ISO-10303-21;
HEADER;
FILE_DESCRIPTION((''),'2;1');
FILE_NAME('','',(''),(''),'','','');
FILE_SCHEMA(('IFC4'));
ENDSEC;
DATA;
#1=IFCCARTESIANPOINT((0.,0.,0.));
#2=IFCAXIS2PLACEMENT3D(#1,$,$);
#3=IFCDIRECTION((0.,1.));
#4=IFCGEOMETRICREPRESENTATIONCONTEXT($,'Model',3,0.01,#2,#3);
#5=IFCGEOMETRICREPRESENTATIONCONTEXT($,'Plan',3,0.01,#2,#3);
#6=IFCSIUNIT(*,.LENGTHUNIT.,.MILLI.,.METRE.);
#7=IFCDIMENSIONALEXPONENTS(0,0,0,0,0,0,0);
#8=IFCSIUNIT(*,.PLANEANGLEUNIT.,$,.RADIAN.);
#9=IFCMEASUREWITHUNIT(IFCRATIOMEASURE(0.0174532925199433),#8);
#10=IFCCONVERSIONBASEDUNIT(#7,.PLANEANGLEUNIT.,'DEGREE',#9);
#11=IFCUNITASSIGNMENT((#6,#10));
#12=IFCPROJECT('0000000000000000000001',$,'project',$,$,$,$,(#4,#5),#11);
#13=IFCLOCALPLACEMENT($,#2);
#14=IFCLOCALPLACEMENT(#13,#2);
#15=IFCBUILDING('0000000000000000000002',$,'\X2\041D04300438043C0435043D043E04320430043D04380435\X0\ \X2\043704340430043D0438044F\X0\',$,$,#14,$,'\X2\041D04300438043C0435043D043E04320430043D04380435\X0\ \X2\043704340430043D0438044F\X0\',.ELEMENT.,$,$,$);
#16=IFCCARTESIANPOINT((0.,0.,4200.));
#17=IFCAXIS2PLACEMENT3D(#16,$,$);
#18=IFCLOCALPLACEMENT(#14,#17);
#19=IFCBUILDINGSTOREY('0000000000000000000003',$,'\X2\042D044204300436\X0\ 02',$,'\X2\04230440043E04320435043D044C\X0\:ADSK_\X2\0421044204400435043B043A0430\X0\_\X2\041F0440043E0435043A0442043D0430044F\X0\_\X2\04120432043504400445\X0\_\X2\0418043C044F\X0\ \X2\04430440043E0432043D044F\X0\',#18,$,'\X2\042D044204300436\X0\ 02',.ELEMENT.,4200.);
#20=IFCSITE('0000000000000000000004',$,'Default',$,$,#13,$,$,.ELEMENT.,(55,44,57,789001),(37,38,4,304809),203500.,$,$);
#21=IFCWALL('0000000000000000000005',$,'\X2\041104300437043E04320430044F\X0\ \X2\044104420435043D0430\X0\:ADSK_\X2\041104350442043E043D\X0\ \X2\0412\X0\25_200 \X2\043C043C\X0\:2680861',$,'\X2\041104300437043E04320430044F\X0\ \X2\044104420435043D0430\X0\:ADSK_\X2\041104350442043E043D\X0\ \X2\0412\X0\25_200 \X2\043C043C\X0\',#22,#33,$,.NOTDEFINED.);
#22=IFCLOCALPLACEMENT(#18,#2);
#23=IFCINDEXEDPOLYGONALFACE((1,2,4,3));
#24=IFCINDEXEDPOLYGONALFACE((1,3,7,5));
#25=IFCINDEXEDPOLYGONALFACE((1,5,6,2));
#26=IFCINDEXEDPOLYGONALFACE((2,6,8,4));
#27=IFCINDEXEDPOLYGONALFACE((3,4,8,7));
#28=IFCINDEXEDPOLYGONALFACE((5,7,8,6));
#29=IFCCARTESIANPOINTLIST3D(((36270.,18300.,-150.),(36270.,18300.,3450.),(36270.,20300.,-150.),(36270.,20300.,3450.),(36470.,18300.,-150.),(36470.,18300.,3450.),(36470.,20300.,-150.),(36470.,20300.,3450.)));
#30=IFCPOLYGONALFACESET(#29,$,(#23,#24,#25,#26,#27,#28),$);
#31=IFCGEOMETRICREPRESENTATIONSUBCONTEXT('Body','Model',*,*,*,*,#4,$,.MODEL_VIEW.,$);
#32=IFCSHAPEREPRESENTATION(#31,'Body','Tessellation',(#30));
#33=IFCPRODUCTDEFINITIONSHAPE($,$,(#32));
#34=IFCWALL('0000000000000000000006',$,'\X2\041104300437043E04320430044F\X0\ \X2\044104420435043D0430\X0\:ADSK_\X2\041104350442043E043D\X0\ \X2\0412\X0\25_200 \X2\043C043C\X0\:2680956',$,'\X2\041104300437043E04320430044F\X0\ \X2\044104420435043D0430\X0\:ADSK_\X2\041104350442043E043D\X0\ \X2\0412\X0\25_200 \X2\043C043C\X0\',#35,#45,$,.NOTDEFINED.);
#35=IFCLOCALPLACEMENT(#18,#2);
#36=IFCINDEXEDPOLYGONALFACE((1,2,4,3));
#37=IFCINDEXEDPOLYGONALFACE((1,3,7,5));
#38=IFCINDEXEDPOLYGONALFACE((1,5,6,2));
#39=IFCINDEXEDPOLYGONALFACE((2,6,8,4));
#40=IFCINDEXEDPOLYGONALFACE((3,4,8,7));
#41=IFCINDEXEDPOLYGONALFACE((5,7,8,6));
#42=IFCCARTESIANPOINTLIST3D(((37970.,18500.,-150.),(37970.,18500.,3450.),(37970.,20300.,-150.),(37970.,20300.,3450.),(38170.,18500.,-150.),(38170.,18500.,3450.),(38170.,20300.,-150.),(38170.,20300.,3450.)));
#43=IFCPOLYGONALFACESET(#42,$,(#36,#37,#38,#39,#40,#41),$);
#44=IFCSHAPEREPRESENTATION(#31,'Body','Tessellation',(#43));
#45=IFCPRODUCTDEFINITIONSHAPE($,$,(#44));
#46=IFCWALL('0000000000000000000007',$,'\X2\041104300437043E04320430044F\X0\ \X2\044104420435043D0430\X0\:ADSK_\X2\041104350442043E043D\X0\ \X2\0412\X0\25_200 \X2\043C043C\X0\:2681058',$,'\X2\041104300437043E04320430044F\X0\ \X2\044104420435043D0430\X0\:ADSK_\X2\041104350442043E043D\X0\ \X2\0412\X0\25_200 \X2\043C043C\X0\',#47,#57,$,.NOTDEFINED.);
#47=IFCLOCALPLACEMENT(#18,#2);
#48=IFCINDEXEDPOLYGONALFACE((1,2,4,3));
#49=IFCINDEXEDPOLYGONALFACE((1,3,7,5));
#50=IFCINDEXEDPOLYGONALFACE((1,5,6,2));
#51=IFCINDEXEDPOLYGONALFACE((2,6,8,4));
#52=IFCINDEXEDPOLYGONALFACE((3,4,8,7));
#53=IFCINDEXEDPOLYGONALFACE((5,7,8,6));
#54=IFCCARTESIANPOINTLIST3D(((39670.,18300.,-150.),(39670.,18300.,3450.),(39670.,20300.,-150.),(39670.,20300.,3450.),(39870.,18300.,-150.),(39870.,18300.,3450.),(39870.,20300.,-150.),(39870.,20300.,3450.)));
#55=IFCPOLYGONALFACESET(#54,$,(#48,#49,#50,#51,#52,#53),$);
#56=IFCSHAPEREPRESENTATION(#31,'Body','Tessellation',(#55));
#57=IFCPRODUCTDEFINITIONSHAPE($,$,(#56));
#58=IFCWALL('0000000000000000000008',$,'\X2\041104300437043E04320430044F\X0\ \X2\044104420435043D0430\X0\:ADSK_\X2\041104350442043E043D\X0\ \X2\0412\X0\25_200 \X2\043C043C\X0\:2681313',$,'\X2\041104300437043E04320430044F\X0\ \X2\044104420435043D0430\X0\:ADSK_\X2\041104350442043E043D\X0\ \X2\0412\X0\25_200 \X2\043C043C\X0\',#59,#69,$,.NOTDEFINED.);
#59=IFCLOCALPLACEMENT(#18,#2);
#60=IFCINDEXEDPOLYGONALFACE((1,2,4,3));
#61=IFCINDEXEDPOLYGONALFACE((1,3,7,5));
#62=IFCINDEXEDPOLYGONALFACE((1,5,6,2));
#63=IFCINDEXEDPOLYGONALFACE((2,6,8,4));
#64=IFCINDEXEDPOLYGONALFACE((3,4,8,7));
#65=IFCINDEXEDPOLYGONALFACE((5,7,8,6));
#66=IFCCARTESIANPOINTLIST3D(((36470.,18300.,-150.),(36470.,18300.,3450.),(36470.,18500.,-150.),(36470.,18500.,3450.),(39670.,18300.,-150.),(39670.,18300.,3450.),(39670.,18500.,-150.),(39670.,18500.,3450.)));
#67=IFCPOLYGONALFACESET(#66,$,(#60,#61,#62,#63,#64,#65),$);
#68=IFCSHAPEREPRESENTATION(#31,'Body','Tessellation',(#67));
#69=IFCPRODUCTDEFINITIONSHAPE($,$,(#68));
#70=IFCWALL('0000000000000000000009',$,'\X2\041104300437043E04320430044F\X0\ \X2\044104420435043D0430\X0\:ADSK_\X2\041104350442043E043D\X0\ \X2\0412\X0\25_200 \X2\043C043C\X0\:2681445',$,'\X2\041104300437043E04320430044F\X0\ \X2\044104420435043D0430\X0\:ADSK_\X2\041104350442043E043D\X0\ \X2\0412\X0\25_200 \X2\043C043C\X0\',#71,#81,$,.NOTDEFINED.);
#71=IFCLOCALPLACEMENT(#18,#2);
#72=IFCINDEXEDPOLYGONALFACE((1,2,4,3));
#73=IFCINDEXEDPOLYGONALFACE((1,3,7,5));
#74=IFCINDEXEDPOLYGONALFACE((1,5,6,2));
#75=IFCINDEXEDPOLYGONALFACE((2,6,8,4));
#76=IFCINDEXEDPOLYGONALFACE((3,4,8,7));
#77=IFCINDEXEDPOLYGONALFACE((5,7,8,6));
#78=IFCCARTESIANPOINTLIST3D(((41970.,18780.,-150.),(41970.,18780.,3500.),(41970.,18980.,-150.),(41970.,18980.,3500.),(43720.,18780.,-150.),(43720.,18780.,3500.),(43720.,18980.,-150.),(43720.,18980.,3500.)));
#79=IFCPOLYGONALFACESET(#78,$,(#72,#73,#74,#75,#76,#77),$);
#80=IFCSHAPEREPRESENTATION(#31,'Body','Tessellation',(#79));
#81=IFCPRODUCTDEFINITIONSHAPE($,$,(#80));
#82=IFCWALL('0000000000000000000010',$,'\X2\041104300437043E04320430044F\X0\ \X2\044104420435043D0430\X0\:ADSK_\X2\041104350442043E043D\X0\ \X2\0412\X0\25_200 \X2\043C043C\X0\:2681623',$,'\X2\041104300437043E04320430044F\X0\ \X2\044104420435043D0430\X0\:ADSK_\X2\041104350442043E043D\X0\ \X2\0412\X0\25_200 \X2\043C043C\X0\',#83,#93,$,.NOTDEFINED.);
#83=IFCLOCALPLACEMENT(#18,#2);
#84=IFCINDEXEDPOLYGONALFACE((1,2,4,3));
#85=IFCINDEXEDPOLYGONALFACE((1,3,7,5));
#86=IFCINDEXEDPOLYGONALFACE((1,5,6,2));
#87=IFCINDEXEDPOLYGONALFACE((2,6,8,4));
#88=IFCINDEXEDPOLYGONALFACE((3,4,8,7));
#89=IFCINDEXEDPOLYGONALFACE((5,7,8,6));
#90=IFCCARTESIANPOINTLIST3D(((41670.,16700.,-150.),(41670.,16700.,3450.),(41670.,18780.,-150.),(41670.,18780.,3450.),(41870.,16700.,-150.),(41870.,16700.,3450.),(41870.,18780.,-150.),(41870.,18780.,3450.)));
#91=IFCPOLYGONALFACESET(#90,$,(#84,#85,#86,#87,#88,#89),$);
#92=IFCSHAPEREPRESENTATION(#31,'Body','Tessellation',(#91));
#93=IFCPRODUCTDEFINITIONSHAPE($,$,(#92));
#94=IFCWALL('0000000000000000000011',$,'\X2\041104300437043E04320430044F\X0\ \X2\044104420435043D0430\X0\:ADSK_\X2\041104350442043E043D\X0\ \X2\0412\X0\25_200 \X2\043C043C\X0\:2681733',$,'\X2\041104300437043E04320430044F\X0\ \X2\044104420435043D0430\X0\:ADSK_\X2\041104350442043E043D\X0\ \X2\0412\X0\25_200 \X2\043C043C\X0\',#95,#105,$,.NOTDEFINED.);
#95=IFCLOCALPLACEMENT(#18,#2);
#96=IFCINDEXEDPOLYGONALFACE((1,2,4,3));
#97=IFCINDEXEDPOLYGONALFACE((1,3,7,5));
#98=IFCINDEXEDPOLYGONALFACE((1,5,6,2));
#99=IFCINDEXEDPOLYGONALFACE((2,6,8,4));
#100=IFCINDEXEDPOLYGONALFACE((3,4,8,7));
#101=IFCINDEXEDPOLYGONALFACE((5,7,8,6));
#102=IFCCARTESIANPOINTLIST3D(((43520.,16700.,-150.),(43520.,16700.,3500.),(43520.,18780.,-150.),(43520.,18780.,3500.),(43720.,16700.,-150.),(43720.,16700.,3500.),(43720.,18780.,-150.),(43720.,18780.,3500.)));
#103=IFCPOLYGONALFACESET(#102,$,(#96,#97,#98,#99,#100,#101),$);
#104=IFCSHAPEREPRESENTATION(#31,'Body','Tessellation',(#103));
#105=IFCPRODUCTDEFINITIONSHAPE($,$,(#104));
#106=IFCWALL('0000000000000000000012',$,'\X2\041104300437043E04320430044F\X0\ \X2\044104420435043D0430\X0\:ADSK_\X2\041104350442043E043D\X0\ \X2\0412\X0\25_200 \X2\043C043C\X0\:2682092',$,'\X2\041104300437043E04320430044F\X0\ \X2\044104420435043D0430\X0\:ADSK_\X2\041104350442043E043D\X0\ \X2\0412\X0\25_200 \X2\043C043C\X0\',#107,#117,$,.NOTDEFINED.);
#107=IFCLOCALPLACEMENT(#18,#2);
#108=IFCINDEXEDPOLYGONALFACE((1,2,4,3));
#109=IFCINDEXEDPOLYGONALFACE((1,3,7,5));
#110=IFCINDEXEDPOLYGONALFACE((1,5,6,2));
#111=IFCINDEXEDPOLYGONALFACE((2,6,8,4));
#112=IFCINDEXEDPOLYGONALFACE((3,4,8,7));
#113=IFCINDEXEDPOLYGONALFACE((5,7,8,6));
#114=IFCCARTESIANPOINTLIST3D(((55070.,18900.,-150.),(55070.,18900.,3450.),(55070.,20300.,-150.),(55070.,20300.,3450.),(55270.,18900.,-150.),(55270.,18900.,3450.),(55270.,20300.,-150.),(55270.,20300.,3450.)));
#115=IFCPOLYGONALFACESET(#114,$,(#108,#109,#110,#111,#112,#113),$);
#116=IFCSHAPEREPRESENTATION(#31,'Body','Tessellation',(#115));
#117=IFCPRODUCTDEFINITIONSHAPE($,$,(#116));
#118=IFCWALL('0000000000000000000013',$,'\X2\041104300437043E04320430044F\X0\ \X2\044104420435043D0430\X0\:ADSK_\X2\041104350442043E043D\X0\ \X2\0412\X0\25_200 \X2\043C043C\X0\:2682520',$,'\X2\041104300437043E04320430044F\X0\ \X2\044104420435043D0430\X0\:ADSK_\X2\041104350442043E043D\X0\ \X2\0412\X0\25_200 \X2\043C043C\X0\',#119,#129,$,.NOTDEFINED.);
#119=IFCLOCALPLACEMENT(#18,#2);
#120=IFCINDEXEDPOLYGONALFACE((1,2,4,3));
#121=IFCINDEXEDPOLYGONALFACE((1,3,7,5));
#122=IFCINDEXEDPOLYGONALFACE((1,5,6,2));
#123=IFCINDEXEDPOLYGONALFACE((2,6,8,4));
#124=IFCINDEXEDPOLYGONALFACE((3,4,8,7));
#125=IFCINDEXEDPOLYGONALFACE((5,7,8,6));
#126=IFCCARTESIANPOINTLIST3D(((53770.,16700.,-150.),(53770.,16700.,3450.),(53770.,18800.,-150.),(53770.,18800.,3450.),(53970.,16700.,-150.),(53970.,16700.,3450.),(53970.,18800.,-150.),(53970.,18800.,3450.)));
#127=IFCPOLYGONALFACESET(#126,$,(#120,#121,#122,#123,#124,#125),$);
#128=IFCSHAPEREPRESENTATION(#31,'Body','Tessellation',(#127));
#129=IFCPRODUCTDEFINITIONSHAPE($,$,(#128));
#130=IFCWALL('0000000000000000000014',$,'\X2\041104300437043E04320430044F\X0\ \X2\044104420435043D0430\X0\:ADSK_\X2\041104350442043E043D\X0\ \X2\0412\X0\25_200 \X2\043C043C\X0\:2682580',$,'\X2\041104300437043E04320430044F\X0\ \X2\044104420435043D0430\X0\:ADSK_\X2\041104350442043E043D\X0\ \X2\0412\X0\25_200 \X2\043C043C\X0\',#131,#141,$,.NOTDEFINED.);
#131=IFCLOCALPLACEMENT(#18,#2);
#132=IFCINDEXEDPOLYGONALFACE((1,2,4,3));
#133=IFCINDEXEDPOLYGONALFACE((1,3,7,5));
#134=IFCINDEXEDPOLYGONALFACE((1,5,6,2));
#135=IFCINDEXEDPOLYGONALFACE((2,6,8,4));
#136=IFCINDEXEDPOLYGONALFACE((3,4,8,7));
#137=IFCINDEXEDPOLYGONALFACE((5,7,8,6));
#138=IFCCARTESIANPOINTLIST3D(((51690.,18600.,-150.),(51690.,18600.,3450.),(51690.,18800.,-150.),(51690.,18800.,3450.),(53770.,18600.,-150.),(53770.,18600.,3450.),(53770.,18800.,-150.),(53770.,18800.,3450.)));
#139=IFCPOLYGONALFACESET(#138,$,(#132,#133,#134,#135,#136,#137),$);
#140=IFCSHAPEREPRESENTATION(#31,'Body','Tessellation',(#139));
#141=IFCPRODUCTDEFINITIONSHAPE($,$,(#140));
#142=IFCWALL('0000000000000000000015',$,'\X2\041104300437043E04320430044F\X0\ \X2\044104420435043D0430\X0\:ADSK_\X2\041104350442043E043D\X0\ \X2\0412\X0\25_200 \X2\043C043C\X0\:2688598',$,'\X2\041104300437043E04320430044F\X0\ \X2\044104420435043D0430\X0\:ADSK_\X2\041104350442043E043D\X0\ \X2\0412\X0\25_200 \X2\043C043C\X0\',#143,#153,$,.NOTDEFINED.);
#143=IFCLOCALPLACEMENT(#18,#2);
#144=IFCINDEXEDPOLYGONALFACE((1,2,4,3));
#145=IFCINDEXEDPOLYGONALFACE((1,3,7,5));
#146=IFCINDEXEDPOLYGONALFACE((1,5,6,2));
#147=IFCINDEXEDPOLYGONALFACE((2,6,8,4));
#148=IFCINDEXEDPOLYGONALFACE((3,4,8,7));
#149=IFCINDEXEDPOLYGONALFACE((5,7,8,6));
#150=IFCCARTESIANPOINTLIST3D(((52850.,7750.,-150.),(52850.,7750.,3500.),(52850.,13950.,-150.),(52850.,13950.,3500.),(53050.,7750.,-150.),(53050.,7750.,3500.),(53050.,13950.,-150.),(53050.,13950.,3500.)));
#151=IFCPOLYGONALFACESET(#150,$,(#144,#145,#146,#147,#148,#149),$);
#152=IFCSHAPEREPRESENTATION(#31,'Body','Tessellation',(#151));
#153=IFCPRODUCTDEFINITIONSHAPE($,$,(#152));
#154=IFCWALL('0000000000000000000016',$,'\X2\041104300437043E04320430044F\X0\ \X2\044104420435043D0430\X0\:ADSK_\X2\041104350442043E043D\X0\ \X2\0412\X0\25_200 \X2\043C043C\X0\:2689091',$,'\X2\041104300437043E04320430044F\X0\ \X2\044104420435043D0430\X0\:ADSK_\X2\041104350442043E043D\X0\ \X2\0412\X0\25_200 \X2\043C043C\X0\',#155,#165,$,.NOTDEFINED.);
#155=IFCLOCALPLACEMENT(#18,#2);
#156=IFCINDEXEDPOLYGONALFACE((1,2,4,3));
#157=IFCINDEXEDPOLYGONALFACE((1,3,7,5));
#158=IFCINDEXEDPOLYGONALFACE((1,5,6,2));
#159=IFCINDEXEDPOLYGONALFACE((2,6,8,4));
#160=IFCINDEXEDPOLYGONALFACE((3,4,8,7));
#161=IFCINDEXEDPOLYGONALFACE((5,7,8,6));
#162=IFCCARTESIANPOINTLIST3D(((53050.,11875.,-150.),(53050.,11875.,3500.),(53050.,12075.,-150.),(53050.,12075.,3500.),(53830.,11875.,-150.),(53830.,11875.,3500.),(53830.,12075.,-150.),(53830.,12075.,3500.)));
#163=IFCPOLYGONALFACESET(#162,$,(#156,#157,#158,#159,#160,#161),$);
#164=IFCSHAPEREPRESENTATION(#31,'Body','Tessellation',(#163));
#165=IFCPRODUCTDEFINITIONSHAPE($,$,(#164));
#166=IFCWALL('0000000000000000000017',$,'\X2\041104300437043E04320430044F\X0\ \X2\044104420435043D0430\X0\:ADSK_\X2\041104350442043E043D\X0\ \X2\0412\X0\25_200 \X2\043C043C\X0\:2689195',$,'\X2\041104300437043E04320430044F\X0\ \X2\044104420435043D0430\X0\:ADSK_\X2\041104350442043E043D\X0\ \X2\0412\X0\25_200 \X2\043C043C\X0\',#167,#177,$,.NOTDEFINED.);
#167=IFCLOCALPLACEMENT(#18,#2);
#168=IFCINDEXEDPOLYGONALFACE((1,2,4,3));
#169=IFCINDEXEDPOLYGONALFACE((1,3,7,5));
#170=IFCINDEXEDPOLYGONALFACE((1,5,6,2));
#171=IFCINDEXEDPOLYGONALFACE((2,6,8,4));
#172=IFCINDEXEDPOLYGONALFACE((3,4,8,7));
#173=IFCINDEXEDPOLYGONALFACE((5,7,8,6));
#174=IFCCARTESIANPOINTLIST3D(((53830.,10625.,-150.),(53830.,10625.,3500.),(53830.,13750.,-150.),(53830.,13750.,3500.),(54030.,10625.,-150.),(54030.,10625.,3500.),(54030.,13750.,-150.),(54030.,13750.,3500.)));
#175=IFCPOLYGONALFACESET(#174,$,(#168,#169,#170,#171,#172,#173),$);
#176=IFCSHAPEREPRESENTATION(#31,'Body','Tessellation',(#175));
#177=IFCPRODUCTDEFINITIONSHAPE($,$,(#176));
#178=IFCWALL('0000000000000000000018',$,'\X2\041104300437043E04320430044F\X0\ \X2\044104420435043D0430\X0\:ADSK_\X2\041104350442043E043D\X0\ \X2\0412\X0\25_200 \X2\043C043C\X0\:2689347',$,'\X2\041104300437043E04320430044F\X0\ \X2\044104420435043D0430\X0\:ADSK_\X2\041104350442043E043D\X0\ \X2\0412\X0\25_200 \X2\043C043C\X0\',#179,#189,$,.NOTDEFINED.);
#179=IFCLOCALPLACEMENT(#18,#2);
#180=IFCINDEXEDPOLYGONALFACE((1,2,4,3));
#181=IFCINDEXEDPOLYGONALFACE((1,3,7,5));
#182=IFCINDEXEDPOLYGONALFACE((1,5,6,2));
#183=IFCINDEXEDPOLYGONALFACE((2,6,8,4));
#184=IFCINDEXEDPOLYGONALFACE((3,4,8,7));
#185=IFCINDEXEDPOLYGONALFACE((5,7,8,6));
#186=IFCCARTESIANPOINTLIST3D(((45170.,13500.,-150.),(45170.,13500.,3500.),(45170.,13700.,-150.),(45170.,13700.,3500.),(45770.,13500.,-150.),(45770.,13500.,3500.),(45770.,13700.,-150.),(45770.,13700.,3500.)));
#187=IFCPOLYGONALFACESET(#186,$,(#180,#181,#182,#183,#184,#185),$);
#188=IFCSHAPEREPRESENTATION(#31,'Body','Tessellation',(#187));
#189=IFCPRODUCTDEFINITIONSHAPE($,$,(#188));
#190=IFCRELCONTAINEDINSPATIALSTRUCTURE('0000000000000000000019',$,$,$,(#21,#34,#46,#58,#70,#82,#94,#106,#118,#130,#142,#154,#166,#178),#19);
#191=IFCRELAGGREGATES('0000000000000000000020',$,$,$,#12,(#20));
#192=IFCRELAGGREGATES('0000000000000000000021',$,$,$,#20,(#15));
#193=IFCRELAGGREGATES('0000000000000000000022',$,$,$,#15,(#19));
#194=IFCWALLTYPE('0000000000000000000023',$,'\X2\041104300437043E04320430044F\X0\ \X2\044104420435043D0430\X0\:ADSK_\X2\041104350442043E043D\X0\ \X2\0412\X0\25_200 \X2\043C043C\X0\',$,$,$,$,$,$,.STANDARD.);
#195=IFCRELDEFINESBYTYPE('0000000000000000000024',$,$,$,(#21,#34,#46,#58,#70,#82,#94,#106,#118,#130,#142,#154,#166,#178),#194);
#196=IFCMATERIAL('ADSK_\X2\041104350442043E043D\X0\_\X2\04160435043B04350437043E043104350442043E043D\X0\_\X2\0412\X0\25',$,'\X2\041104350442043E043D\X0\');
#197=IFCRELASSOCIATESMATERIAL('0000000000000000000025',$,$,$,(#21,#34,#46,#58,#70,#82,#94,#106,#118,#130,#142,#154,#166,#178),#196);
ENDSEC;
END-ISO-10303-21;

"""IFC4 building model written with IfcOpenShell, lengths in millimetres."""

from ifc_helpers import new_model, entity, si_unit, converted_unit, direction, frame, origin, place, context, subcontext, project, spatial, indexed_curve, outline, extrude, material, type_object, element, save


model = new_model("IFC4")

# Units and contexts
model_context = context("Model", 3, precision=0.01, world=origin(), true_north=direction((0.0, 1.0)))
plan_context = context("Plan", 3, precision=0.01, world=origin(), true_north=direction((0.0, 1.0)))
body_context = subcontext(model_context, "Body", "Model", "MODEL_VIEW")
ifc_project = project(units=[si_unit("LENGTHUNIT", "METRE", prefix="MILLI"), converted_unit("PLANEANGLEUNIT", "DEGREE", entity("IfcRatioMeasure", 0.0174532925199433), si_unit("PLANEANGLEUNIT", "RADIAN"), dimensions=[0, 0, 0, 0, 0, 0, 0])], contexts=[model_context, plan_context])

# Site, building, storey
site_placement = place(None, origin())
site = spatial("IfcSite", under=ifc_project, at=site_placement, Name="Default", CompositionType="ELEMENT", RefLatitude=(55, 44, 57, 789001), RefLongitude=(37, 38, 4, 304809), RefElevation=203500.0)
building_placement = place(site_placement, origin())
building = spatial("IfcBuilding", under=site, at=building_placement, Name="Наименование здания", LongName="Наименование здания", CompositionType="ELEMENT")
storey_placement = place(building_placement, frame((0.0, 0.0, 4200.0)))
storey = spatial("IfcBuildingStorey", under=building, at=storey_placement, Name="Этаж 02", ObjectType="Уровень:ADSK_Стрелка_Проектная_Вверх_Имя уровня", LongName="Этаж 02", CompositionType="ELEMENT", Elevation=4200.0)

# Walls
ifc_material = material(Name="ADSK_Бетон_Железобетон_В25", Category="Бетон")
wall_type_1 = type_object("IfcWallType", Name="Базовая стена:ADSK_Бетон В25_200 мм", PredefinedType="STANDARD")
wall_1_placement = place(storey_placement, frame((36370.0, 20300.0, -150.0), z_axis=(0.0, 0.0, 1.0), x_axis=(0.0, -1.0, 0.0)))
element("IfcWall", 1, at=wall_1_placement, inside=storey, type_object=wall_type_1, material=ifc_material, Name="Базовая стена:ADSK_Бетон В25_200 мм:2680861", ObjectType="Базовая стена:ADSK_Бетон В25_200 мм", PredefinedType="NOTDEFINED", context=body_context, shape_type="SweptSolid", body=[
    extrude(outline(indexed_curve([(2000.0, 100.0), (0.0, 100.0), (0.0, -100.0), (2000.0, -100.0), (2000.0, 100.0)], self_intersect=False)), origin(), (0.0, 0.0, 1.0), 3600.0),
])
wall_2_placement = place(storey_placement, frame((38070.0, 20300.0, -150.0), z_axis=(0.0, 0.0, 1.0), x_axis=(0.0, -1.0, 0.0)))
element("IfcWall", 2, at=wall_2_placement, inside=storey, type_object=wall_type_1, material=ifc_material, Name="Базовая стена:ADSK_Бетон В25_200 мм:2680956", ObjectType="Базовая стена:ADSK_Бетон В25_200 мм", PredefinedType="NOTDEFINED", context=body_context, shape_type="SweptSolid", body=[
    extrude(outline(indexed_curve([(1800.0, 100.0), (0.0, 100.0), (0.0, -100.0), (1800.0, -100.0), (1800.0, 100.0)], self_intersect=False)), origin(), (0.0, 0.0, 1.0), 3600.0),
])
wall_3_placement = place(storey_placement, frame((39770.0, 20300.0, -150.0), z_axis=(0.0, 0.0, 1.0), x_axis=(0.0, -1.0, 0.0)))
element("IfcWall", 3, at=wall_3_placement, inside=storey, type_object=wall_type_1, material=ifc_material, Name="Базовая стена:ADSK_Бетон В25_200 мм:2681058", ObjectType="Базовая стена:ADSK_Бетон В25_200 мм", PredefinedType="NOTDEFINED", context=body_context, shape_type="SweptSolid", body=[
    extrude(outline(indexed_curve([(2000.0, 100.0), (0.0, 100.0), (0.0, -100.0), (2000.0, -100.0), (2000.0, 100.0)], self_intersect=False)), origin(), (0.0, 0.0, 1.0), 3600.0),
])
wall_4_placement = place(storey_placement, frame((36470.0, 18400.0, -150.0)))
element("IfcWall", 4, at=wall_4_placement, inside=storey, type_object=wall_type_1, material=ifc_material, Name="Базовая стена:ADSK_Бетон В25_200 мм:2681313", ObjectType="Базовая стена:ADSK_Бетон В25_200 мм", PredefinedType="NOTDEFINED", context=body_context, shape_type="SweptSolid", body=[
    extrude(outline(indexed_curve([(3200.0, 100.0), (0.0, 100.0), (0.0, -100.0), (3200.0, -100.0), (3200.0, 100.0)], self_intersect=False)), origin(), (0.0, 0.0, 1.0), 3600.0),
])
wall_5_placement = place(storey_placement, frame((41970.0, 18880.0, -150.0)))
element("IfcWall", 5, at=wall_5_placement, inside=storey, type_object=wall_type_1, material=ifc_material, Name="Базовая стена:ADSK_Бетон В25_200 мм:2681445", ObjectType="Базовая стена:ADSK_Бетон В25_200 мм", PredefinedType="NOTDEFINED", context=body_context, shape_type="SweptSolid", body=[
    extrude(outline(indexed_curve([(1750.0, 100.0), (0.0, 100.0), (0.0, -100.0), (1750.0, -100.0), (1750.0, 100.0)], self_intersect=False)), origin(), (0.0, 0.0, 1.0), 3650.0),
])
wall_6_placement = place(storey_placement, frame((41770.0, 18780.0, -150.0), z_axis=(0.0, 0.0, 1.0), x_axis=(0.0, -1.0, 0.0)))
element("IfcWall", 6, at=wall_6_placement, inside=storey, type_object=wall_type_1, material=ifc_material, Name="Базовая стена:ADSK_Бетон В25_200 мм:2681623", ObjectType="Базовая стена:ADSK_Бетон В25_200 мм", PredefinedType="NOTDEFINED", context=body_context, shape_type="SweptSolid", body=[
    extrude(outline(indexed_curve([(2080.0, 100.0), (0.0, 100.0), (0.0, -100.0), (2080.0, -100.0), (2080.0, 100.0)], self_intersect=False)), origin(), (0.0, 0.0, 1.0), 3600.0),
])
wall_7_placement = place(storey_placement, frame((43620.0, 16700.0, -150.0), z_axis=(0.0, 0.0, 1.0), x_axis=(0.0, 1.0, 0.0)))
element("IfcWall", 7, at=wall_7_placement, inside=storey, type_object=wall_type_1, material=ifc_material, Name="Базовая стена:ADSK_Бетон В25_200 мм:2681733", ObjectType="Базовая стена:ADSK_Бетон В25_200 мм", PredefinedType="NOTDEFINED", context=body_context, shape_type="SweptSolid", body=[
    extrude(outline(indexed_curve([(2080.0, 100.0), (0.0, 100.0), (0.0, -100.0), (2080.0, -100.0), (2080.0, 100.0)], self_intersect=False)), origin(), (0.0, 0.0, 1.0), 3650.0),
])
wall_8_placement = place(storey_placement, frame((55170.0, 20300.0, -150.0), z_axis=(0.0, 0.0, 1.0), x_axis=(0.0, -1.0, 0.0)))
element("IfcWall", 8, at=wall_8_placement, inside=storey, type_object=wall_type_1, material=ifc_material, Name="Базовая стена:ADSK_Бетон В25_200 мм:2682092", ObjectType="Базовая стена:ADSK_Бетон В25_200 мм", PredefinedType="NOTDEFINED", context=body_context, shape_type="SweptSolid", body=[
    extrude(outline(indexed_curve([(1400.0, 100.0), (0.0, 100.0), (0.0, -100.0), (1400.0, -100.0), (1400.0, 100.0)], self_intersect=False)), origin(), (0.0, 0.0, 1.0), 3600.0),
])
wall_9_placement = place(storey_placement, frame((53870.0, 16700.0, -150.0), z_axis=(0.0, 0.0, 1.0), x_axis=(0.0, 1.0, 0.0)))
element("IfcWall", 9, at=wall_9_placement, inside=storey, type_object=wall_type_1, material=ifc_material, Name="Базовая стена:ADSK_Бетон В25_200 мм:2682520", ObjectType="Базовая стена:ADSK_Бетон В25_200 мм", PredefinedType="NOTDEFINED", context=body_context, shape_type="SweptSolid", body=[
    extrude(outline(indexed_curve([(2100.0, 100.0), (0.0, 100.0), (0.0, -100.0), (2100.0, -100.0), (2100.0, 100.0)], self_intersect=False)), origin(), (0.0, 0.0, 1.0), 3600.0),
])
wall_10_placement = place(storey_placement, frame((53770.0, 18700.0, -150.0), z_axis=(0.0, 0.0, 1.0), x_axis=(-1.0, 0.0, 0.0)))
element("IfcWall", 10, at=wall_10_placement, inside=storey, type_object=wall_type_1, material=ifc_material, Name="Базовая стена:ADSK_Бетон В25_200 мм:2682580", ObjectType="Базовая стена:ADSK_Бетон В25_200 мм", PredefinedType="NOTDEFINED", context=body_context, shape_type="SweptSolid", body=[
    extrude(outline(indexed_curve([(2080.0, 100.0), (0.0, 100.0), (0.0, -100.0), (2080.0, -100.0), (2080.0, 100.0)], self_intersect=False)), origin(), (0.0, 0.0, 1.0), 3600.0),
])
wall_11_placement = place(storey_placement, frame((52950.0, 7750.0, -150.0), z_axis=(0.0, 0.0, 1.0), x_axis=(0.0, 1.0, 0.0)))
element("IfcWall", 11, at=wall_11_placement, inside=storey, type_object=wall_type_1, material=ifc_material, Name="Базовая стена:ADSK_Бетон В25_200 мм:2688598", ObjectType="Базовая стена:ADSK_Бетон В25_200 мм", PredefinedType="NOTDEFINED", context=body_context, shape_type="SweptSolid", body=[
    extrude(outline(indexed_curve([(6200.0, 100.0), (0.0, 100.0), (0.0, -100.0), (6200.0, -100.0), (6200.0, 100.0)], self_intersect=False)), origin(), (0.0, 0.0, 1.0), 3650.0),
])
wall_12_placement = place(storey_placement, frame((53050.0, 11975.0, -150.0)))
element("IfcWall", 12, at=wall_12_placement, inside=storey, type_object=wall_type_1, material=ifc_material, Name="Базовая стена:ADSK_Бетон В25_200 мм:2689091", ObjectType="Базовая стена:ADSK_Бетон В25_200 мм", PredefinedType="NOTDEFINED", context=body_context, shape_type="SweptSolid", body=[
    extrude(outline(indexed_curve([(780.0, 100.0), (0.0, 100.0), (0.0, -100.0), (780.0, -100.0), (780.0, 100.0)], self_intersect=False)), origin(), (0.0, 0.0, 1.0), 3650.0),
])
wall_13_placement = place(storey_placement, frame((53930.0, 10625.0, -150.0), z_axis=(0.0, 0.0, 1.0), x_axis=(0.0, 1.0, 0.0)))
element("IfcWall", 13, at=wall_13_placement, inside=storey, type_object=wall_type_1, material=ifc_material, Name="Базовая стена:ADSK_Бетон В25_200 мм:2689195", ObjectType="Базовая стена:ADSK_Бетон В25_200 мм", PredefinedType="NOTDEFINED", context=body_context, shape_type="SweptSolid", body=[
    extrude(outline(indexed_curve([(3125.0, 100.0), (0.0, 100.0), (0.0, -100.0), (3125.0, -100.0), (3125.0, 100.0)], self_intersect=False)), origin(), (0.0, 0.0, 1.0), 3650.0),
])
wall_14_placement = place(storey_placement, frame((45170.0, 13600.0, -150.0)))
element("IfcWall", 14, at=wall_14_placement, inside=storey, type_object=wall_type_1, material=ifc_material, Name="Базовая стена:ADSK_Бетон В25_200 мм:2689347", ObjectType="Базовая стена:ADSK_Бетон В25_200 мм", PredefinedType="NOTDEFINED", context=body_context, shape_type="SweptSolid", body=[
    extrude(outline(indexed_curve([(600.0, 100.0), (0.0, 100.0), (0.0, -100.0), (600.0, -100.0), (600.0, 100.0)], self_intersect=False)), origin(), (0.0, 0.0, 1.0), 3650.0),
])

save(model, "model.ifc")
